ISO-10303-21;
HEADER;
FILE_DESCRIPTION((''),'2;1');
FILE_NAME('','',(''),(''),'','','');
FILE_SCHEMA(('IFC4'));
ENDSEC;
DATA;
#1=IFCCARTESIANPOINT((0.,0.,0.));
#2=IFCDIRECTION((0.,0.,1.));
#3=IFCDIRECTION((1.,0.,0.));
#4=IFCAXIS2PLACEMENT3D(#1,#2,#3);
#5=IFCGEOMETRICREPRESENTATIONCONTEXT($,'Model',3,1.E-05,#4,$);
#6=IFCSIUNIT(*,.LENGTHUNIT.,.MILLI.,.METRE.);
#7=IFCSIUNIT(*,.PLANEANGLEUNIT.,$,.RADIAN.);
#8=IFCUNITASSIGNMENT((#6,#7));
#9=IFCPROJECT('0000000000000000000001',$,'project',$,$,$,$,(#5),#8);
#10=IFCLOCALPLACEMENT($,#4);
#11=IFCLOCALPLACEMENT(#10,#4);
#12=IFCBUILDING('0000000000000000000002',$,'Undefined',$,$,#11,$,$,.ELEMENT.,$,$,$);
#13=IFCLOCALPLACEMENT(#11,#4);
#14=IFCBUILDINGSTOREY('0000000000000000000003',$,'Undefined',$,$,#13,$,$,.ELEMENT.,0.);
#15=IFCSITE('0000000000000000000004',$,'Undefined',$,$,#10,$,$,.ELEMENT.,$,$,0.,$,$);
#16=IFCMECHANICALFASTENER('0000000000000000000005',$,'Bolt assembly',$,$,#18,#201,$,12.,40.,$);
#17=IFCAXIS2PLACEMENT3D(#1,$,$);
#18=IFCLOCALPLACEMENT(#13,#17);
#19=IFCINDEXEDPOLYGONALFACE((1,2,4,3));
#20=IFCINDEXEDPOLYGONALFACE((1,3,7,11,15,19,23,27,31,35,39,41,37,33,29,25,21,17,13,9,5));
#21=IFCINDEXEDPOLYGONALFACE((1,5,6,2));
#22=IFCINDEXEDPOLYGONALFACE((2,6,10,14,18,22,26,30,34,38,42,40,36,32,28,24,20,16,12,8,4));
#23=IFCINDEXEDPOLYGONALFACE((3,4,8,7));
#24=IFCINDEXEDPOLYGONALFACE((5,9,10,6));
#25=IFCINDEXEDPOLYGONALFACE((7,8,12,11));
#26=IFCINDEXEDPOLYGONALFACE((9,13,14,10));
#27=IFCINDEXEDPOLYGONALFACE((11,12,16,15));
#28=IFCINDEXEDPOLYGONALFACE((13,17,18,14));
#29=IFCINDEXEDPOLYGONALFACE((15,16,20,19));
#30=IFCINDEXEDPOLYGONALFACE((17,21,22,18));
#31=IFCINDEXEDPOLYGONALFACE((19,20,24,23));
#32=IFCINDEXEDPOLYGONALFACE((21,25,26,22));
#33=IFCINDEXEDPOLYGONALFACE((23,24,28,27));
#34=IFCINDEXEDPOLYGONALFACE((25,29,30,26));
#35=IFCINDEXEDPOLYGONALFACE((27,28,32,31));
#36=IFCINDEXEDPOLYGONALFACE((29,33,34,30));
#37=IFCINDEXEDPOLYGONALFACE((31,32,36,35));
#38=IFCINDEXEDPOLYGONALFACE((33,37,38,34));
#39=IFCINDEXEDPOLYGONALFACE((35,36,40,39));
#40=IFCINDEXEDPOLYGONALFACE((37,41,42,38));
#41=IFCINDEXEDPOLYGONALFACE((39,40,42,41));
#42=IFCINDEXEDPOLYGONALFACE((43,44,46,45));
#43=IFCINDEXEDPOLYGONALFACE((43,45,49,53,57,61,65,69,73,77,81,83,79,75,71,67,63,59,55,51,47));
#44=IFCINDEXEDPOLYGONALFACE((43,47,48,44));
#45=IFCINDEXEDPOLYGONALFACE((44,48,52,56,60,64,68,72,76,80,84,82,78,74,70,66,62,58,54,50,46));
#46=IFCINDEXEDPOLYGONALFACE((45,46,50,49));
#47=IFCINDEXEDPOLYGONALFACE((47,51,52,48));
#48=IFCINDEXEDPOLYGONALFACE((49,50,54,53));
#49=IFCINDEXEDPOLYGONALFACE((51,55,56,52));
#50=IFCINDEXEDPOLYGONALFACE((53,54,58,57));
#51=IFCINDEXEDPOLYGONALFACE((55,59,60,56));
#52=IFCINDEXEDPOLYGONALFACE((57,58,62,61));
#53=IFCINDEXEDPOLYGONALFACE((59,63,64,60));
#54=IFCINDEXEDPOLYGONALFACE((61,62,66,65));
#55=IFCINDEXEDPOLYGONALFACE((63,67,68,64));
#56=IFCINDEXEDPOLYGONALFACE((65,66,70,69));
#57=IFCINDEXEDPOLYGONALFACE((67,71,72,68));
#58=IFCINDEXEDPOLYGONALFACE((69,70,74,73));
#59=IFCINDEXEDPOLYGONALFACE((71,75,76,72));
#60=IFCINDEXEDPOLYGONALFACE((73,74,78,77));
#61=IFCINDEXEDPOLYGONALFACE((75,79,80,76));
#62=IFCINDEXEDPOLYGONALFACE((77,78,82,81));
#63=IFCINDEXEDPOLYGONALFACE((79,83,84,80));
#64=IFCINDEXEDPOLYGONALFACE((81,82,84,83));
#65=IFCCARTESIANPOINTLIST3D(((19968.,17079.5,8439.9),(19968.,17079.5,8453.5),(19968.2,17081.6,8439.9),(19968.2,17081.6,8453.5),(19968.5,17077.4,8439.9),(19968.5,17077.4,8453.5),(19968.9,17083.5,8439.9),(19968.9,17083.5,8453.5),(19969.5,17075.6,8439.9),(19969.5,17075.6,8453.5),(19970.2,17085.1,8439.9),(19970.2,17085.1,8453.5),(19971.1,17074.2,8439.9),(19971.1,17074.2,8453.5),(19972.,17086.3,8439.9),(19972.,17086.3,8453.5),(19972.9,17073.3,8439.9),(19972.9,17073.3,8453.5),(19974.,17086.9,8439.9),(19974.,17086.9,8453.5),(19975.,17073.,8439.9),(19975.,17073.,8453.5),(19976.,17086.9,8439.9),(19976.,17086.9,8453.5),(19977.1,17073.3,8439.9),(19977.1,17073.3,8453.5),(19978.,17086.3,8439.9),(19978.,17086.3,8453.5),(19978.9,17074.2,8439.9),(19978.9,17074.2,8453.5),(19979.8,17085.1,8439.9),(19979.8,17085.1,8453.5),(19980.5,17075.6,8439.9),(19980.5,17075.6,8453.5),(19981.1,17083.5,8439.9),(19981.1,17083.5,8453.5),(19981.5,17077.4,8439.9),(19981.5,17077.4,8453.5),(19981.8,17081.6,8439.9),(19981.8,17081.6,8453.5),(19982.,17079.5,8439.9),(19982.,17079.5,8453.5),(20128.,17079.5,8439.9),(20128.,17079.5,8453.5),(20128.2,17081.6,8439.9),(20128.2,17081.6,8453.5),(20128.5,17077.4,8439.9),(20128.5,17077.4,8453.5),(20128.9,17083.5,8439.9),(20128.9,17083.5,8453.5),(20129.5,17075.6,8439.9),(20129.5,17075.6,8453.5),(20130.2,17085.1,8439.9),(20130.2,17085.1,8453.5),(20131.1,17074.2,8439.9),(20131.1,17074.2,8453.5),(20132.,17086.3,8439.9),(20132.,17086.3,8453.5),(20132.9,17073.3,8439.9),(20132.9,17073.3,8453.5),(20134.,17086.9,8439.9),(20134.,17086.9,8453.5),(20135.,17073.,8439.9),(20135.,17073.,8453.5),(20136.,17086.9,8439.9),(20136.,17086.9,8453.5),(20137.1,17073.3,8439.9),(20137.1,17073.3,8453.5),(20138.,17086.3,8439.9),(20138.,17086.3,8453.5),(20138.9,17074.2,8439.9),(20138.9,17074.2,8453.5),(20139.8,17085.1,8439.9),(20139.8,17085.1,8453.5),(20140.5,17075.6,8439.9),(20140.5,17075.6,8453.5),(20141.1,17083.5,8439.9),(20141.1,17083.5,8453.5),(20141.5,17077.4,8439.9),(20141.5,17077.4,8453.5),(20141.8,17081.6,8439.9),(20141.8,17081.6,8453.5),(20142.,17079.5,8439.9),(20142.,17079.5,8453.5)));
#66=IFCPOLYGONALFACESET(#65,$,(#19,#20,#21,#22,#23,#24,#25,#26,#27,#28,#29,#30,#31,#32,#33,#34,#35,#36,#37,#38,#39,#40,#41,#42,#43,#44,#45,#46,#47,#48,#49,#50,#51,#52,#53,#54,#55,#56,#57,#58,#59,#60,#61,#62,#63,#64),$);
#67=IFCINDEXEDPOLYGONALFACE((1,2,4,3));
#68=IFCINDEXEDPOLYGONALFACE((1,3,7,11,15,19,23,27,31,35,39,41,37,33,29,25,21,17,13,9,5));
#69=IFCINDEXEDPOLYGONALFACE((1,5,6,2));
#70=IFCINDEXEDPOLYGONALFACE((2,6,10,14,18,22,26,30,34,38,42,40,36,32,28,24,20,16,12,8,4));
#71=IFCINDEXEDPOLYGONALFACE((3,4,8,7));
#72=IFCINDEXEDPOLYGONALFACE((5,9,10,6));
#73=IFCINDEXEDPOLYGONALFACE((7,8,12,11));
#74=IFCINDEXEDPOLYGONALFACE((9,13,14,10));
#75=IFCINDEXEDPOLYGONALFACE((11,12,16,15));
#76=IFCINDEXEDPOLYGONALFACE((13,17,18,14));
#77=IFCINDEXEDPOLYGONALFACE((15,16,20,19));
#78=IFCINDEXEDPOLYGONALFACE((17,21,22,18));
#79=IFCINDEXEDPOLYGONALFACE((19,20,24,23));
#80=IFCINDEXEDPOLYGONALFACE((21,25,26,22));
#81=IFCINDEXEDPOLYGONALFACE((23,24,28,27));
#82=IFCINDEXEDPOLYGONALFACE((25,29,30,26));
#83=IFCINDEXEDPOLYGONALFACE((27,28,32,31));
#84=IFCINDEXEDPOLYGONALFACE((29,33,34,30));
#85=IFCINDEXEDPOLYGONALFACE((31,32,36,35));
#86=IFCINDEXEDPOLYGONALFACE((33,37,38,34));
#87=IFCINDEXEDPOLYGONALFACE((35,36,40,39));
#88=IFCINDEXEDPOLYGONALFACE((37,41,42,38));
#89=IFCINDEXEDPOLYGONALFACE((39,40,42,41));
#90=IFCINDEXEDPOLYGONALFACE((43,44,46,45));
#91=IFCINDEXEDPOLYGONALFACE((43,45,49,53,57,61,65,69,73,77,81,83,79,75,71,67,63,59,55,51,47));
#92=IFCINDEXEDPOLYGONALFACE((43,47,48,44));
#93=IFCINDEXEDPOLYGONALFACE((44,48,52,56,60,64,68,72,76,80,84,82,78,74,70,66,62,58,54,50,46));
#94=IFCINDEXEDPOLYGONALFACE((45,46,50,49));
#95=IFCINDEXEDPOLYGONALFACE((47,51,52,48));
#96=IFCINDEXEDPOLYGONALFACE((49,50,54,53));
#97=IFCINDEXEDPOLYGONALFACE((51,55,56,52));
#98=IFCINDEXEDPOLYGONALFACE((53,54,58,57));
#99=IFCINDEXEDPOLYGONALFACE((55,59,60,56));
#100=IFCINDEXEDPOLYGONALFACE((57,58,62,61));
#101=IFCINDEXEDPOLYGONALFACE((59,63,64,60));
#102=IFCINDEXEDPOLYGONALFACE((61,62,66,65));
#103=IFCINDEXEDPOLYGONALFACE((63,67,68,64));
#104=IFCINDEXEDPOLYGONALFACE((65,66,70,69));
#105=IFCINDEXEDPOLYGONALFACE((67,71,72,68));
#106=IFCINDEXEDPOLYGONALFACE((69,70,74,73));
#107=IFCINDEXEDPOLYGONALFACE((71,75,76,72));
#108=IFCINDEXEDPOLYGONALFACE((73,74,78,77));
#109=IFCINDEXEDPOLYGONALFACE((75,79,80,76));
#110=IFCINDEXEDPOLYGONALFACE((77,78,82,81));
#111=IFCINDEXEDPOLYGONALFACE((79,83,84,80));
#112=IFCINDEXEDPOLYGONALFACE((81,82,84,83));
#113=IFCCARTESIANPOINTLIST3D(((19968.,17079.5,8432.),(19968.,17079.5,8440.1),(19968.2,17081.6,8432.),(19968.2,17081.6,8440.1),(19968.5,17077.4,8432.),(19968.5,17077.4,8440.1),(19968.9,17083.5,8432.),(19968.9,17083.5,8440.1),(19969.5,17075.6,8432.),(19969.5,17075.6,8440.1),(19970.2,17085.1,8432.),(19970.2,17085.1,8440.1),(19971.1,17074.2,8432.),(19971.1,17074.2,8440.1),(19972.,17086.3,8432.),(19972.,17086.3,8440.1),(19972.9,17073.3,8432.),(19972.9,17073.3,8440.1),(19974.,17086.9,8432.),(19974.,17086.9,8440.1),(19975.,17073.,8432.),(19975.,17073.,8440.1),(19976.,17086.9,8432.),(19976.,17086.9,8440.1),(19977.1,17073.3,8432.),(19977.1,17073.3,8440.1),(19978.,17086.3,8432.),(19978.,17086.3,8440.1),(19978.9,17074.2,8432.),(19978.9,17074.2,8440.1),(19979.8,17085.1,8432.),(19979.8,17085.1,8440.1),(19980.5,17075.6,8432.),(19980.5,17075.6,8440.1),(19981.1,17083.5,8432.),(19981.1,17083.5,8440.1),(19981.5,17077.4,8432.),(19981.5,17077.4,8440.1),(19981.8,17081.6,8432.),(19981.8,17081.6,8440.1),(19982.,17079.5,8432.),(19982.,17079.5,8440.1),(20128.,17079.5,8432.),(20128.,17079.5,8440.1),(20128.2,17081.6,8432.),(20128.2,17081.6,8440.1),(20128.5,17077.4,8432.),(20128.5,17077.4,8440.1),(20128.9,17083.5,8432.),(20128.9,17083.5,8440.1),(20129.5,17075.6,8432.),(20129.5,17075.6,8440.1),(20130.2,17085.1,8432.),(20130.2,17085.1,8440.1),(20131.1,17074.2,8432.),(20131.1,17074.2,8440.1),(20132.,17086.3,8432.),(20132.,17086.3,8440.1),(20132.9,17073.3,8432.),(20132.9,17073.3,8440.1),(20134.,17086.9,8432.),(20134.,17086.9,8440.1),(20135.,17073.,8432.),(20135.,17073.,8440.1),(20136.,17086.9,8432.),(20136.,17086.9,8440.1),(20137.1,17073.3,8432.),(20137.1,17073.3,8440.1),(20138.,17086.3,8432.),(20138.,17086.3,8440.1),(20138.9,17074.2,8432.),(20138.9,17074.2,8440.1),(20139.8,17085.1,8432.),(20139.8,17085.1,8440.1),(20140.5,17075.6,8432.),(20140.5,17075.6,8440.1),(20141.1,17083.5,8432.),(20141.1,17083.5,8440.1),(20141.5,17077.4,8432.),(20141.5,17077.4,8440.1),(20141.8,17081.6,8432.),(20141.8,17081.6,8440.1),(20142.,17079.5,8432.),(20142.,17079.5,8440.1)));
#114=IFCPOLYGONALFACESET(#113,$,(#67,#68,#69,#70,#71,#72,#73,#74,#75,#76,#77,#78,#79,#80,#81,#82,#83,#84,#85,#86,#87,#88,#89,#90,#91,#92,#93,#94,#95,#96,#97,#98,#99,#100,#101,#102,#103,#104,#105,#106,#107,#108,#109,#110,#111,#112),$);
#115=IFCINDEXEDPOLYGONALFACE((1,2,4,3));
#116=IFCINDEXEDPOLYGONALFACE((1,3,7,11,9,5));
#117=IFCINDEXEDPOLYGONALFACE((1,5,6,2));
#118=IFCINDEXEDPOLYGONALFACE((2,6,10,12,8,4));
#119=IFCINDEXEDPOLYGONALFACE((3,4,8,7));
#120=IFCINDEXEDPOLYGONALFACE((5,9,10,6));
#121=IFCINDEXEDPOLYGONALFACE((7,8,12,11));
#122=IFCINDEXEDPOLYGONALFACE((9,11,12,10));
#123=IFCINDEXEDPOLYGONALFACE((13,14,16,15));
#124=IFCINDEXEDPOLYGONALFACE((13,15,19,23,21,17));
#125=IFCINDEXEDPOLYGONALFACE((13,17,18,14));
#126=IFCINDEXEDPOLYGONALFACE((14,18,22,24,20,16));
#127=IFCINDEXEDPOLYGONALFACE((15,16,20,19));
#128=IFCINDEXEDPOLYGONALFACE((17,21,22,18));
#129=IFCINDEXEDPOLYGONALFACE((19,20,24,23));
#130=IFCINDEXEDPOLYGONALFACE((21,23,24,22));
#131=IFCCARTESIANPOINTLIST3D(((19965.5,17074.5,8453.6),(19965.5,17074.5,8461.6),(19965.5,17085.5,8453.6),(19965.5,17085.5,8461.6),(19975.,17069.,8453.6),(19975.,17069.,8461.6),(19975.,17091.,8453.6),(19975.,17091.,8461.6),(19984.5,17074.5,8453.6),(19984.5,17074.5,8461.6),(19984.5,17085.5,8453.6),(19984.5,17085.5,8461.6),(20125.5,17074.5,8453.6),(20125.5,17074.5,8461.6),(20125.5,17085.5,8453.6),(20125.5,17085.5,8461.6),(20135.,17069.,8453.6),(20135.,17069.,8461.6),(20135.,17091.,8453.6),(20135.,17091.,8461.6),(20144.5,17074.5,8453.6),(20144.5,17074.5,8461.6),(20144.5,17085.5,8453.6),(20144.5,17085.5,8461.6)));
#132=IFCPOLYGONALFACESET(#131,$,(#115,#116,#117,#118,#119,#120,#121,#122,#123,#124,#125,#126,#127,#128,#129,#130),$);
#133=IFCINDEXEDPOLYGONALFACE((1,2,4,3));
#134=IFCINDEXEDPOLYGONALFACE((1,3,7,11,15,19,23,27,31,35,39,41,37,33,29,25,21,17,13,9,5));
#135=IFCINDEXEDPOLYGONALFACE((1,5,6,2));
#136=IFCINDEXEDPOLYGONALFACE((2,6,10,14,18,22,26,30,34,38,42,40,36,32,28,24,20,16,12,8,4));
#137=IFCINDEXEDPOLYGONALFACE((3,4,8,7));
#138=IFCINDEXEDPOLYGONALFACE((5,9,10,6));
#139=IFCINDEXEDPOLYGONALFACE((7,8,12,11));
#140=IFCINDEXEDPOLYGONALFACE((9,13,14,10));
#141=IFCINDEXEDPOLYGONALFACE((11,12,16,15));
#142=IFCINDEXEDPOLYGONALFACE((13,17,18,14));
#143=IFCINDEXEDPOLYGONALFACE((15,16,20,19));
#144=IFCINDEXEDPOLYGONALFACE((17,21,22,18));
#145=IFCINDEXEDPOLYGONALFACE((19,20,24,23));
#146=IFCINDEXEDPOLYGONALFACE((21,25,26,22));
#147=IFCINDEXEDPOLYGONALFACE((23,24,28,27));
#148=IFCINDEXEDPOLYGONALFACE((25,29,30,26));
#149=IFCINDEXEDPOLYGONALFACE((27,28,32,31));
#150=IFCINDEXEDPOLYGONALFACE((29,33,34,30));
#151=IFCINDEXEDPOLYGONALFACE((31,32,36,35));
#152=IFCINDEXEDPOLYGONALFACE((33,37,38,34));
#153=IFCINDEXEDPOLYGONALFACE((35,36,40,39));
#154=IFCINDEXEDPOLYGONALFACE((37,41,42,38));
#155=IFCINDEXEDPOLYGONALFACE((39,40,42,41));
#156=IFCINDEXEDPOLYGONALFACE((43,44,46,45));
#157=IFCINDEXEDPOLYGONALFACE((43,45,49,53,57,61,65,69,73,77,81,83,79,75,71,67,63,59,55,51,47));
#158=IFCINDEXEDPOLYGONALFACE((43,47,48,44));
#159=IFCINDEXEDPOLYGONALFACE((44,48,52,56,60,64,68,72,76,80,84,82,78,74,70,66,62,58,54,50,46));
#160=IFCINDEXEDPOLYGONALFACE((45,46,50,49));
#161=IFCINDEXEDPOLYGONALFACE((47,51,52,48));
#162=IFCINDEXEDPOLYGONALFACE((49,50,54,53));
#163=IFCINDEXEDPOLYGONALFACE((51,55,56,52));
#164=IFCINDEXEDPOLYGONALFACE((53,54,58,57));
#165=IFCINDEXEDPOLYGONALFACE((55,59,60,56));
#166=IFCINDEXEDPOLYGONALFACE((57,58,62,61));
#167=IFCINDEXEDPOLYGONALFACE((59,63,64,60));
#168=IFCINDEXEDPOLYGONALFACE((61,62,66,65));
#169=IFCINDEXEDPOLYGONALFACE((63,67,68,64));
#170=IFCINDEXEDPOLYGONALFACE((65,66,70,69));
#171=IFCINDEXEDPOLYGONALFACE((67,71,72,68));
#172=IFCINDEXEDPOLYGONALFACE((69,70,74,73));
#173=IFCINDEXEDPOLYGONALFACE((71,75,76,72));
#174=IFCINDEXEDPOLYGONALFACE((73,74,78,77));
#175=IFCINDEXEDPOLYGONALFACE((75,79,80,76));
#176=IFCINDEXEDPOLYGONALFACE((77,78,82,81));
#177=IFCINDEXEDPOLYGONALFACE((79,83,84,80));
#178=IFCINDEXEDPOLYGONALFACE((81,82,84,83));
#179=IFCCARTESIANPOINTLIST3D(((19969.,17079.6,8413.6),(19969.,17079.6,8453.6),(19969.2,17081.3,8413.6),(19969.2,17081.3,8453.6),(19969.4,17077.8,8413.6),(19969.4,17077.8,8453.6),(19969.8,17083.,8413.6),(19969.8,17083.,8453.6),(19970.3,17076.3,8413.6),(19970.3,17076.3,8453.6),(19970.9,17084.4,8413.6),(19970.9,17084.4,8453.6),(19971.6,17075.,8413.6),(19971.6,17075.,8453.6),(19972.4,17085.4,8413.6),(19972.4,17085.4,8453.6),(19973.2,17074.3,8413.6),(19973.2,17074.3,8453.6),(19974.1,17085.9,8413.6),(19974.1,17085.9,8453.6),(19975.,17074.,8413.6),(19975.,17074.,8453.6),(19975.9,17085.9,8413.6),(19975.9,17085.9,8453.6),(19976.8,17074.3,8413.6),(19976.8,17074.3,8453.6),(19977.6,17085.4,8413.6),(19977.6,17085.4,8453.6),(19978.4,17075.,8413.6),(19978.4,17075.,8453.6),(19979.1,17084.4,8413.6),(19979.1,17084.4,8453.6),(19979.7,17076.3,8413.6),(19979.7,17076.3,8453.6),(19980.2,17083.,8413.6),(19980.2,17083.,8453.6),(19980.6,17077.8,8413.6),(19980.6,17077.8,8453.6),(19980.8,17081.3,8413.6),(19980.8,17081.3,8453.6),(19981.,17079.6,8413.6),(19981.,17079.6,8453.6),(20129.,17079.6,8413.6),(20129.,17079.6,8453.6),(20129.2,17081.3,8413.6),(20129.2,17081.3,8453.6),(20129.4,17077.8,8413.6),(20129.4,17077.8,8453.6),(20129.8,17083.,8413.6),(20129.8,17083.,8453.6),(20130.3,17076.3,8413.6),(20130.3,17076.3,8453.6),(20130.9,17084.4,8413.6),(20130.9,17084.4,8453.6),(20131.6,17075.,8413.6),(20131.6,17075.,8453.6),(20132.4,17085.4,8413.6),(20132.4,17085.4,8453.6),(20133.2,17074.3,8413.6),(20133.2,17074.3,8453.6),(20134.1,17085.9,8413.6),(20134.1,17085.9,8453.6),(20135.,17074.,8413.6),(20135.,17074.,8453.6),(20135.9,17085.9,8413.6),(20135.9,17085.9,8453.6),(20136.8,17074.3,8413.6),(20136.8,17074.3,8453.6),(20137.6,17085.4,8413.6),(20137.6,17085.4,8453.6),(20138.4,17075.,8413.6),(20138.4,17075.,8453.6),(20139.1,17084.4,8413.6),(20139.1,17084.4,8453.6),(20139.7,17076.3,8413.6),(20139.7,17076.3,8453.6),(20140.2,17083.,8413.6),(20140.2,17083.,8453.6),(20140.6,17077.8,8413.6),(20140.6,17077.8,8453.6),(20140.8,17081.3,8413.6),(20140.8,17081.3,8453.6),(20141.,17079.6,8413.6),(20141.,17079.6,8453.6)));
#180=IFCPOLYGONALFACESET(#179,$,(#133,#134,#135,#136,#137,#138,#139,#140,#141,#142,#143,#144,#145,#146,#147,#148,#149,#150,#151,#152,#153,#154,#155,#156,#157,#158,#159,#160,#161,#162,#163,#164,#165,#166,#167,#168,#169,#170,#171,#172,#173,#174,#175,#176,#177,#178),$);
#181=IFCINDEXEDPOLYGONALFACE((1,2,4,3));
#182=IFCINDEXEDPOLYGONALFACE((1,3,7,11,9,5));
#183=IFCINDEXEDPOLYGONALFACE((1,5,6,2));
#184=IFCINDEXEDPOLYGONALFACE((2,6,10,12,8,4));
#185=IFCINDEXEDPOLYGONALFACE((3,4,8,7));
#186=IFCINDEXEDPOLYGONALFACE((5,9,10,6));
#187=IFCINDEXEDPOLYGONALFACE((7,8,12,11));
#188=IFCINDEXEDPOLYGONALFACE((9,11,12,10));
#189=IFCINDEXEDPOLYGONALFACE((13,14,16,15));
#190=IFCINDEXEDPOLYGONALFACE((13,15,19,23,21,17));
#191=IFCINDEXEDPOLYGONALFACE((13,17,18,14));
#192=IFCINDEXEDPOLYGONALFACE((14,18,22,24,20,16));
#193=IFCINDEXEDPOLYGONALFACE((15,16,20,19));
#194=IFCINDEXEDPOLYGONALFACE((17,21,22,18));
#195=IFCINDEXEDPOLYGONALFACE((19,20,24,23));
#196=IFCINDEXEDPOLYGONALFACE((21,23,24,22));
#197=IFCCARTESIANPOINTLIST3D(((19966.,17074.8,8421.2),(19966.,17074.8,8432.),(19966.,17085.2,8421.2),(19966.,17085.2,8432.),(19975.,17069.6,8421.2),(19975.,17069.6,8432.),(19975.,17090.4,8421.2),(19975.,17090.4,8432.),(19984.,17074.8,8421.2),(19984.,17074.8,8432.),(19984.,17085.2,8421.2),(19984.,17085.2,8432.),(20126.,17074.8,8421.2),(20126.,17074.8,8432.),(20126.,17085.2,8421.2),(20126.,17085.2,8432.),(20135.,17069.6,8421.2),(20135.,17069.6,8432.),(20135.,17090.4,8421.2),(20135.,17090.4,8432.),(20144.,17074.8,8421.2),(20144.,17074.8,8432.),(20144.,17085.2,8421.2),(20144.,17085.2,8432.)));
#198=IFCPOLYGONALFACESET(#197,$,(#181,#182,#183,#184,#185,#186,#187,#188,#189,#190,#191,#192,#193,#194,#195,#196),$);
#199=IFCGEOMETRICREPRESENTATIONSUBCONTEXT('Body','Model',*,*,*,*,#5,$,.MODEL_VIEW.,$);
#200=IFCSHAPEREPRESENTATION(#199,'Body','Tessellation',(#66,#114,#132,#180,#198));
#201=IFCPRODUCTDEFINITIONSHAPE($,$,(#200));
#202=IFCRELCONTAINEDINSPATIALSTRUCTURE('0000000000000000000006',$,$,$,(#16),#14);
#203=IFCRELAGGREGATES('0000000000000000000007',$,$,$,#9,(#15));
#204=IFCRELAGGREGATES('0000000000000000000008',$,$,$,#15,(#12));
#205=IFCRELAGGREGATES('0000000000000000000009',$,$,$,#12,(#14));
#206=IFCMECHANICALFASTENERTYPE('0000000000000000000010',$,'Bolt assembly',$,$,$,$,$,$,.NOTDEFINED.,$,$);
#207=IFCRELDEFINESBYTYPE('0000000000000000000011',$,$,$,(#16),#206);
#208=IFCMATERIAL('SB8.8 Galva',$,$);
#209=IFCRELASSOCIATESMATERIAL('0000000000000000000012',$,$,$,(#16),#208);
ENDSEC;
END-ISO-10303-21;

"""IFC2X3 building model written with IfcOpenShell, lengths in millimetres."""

from ifc_helpers import new_model, si_unit, frame, origin_with_axes, origin_2d_with_axis, place, context, subcontext, project, spatial, polyline, circle, outline, extrude, source, transform, mapped, material, type_object, element, save


model = new_model("IFC2X3")

# Units and contexts
model_context = context("Model", 3, precision=1e-05, world=origin_with_axes())
body_context = subcontext(model_context, "Body", "Model", "MODEL_VIEW")
ifc_project = project(units=[si_unit("LENGTHUNIT", "METRE", prefix="MILLI"), si_unit("PLANEANGLEUNIT", "RADIAN")], contexts=[model_context])

# Site, building, storey
site_placement = place(None, origin_with_axes())
site = spatial("IfcSite", under=ifc_project, at=site_placement, Name="Undefined", CompositionType="ELEMENT", RefElevation=0.0)
building_placement = place(site_placement, origin_with_axes())
building = spatial("IfcBuilding", under=site, at=building_placement, Name="Undefined", CompositionType="ELEMENT")
storey_placement = place(building_placement, origin_with_axes())
storey = spatial("IfcBuildingStorey", under=building, at=storey_placement, Name="Undefined", CompositionType="ELEMENT", Elevation=0.0)

# Mechanical fastener
mechanical_fastener_type = type_object("IfcMechanicalFastenerType", Name="Bolt assembly")
ifc_material_1 = material(Name="SB8.8 Galva")
shared_shape_1 = source(origin_with_axes(), body_context, "Body", "SweptSolid", [
    extrude(circle(Radius=7.0, at=origin_2d_with_axis()), frame((0.0, -13.5, 0.0), z_axis=(0.0, 1.0, 0.0), x_axis=(1.0, 0.0, 0.0)), (0.0, 0.0, 1.0), 13.6),
    extrude(circle(Radius=7.0, at=origin_2d_with_axis()), frame((0.0, -0.1, 0.0), z_axis=(0.0, 1.0, 0.0), x_axis=(1.0, 0.0, 0.0)), (0.0, 0.0, 1.0), 8.1),
    extrude(outline(polyline([(11.0, 0.0), (5.5, 9.5), (-5.5, 9.5), (-11.0, 0.0), (-5.5, -9.5), (5.5, -9.5), (11.0, 0.0)])), frame((0.0, -21.6, 0.0), z_axis=(0.0, 1.0, 0.0), x_axis=(1.0, 0.0, 0.0)), (0.0, 0.0, 1.0), 8.0),
    extrude(circle(Radius=6.0, at=origin_2d_with_axis()), frame((0.0, -13.6, 0.0), z_axis=(0.0, 1.0, 0.0), x_axis=(1.0, 0.0, 0.0)), (0.0, 0.0, 1.0), 40.0),
    extrude(outline(polyline([(10.4, 0.0), (5.2, 9.0), (-5.2, 9.0), (-10.4, 0.0), (-5.2, -9.0), (5.2, -9.0), (10.4, 0.0)])), frame((0.0, 8.0, 0.0), z_axis=(0.0, 1.0, 0.0), x_axis=(1.0, 0.0, 0.0)), (0.0, 0.0, 1.0), 10.8),
])
for number, where, z_axis, x_axis, name in (
    (1, (20055.0, 17080.0, 8440.0), (1.0, 0.0, 0.0), (0.0, -1.0, 0.0), "Bolt assembly"),
):
    element("IfcMechanicalFastener", number, at=place(storey_placement, frame(where, z_axis=z_axis, x_axis=x_axis)), inside=storey, type_object=mechanical_fastener_type, material=ifc_material_1, Name=name, NominalDiameter=12.0, NominalLength=40.0, context=body_context, shape_type="MappedRepresentation", body=[
        mapped(shared_shape_1, transform((0.0, 0.0, -80.0))),
        mapped(shared_shape_1, transform((0.0, 0.0, 80.0))),
    ])

save(model, "model.ifc")
